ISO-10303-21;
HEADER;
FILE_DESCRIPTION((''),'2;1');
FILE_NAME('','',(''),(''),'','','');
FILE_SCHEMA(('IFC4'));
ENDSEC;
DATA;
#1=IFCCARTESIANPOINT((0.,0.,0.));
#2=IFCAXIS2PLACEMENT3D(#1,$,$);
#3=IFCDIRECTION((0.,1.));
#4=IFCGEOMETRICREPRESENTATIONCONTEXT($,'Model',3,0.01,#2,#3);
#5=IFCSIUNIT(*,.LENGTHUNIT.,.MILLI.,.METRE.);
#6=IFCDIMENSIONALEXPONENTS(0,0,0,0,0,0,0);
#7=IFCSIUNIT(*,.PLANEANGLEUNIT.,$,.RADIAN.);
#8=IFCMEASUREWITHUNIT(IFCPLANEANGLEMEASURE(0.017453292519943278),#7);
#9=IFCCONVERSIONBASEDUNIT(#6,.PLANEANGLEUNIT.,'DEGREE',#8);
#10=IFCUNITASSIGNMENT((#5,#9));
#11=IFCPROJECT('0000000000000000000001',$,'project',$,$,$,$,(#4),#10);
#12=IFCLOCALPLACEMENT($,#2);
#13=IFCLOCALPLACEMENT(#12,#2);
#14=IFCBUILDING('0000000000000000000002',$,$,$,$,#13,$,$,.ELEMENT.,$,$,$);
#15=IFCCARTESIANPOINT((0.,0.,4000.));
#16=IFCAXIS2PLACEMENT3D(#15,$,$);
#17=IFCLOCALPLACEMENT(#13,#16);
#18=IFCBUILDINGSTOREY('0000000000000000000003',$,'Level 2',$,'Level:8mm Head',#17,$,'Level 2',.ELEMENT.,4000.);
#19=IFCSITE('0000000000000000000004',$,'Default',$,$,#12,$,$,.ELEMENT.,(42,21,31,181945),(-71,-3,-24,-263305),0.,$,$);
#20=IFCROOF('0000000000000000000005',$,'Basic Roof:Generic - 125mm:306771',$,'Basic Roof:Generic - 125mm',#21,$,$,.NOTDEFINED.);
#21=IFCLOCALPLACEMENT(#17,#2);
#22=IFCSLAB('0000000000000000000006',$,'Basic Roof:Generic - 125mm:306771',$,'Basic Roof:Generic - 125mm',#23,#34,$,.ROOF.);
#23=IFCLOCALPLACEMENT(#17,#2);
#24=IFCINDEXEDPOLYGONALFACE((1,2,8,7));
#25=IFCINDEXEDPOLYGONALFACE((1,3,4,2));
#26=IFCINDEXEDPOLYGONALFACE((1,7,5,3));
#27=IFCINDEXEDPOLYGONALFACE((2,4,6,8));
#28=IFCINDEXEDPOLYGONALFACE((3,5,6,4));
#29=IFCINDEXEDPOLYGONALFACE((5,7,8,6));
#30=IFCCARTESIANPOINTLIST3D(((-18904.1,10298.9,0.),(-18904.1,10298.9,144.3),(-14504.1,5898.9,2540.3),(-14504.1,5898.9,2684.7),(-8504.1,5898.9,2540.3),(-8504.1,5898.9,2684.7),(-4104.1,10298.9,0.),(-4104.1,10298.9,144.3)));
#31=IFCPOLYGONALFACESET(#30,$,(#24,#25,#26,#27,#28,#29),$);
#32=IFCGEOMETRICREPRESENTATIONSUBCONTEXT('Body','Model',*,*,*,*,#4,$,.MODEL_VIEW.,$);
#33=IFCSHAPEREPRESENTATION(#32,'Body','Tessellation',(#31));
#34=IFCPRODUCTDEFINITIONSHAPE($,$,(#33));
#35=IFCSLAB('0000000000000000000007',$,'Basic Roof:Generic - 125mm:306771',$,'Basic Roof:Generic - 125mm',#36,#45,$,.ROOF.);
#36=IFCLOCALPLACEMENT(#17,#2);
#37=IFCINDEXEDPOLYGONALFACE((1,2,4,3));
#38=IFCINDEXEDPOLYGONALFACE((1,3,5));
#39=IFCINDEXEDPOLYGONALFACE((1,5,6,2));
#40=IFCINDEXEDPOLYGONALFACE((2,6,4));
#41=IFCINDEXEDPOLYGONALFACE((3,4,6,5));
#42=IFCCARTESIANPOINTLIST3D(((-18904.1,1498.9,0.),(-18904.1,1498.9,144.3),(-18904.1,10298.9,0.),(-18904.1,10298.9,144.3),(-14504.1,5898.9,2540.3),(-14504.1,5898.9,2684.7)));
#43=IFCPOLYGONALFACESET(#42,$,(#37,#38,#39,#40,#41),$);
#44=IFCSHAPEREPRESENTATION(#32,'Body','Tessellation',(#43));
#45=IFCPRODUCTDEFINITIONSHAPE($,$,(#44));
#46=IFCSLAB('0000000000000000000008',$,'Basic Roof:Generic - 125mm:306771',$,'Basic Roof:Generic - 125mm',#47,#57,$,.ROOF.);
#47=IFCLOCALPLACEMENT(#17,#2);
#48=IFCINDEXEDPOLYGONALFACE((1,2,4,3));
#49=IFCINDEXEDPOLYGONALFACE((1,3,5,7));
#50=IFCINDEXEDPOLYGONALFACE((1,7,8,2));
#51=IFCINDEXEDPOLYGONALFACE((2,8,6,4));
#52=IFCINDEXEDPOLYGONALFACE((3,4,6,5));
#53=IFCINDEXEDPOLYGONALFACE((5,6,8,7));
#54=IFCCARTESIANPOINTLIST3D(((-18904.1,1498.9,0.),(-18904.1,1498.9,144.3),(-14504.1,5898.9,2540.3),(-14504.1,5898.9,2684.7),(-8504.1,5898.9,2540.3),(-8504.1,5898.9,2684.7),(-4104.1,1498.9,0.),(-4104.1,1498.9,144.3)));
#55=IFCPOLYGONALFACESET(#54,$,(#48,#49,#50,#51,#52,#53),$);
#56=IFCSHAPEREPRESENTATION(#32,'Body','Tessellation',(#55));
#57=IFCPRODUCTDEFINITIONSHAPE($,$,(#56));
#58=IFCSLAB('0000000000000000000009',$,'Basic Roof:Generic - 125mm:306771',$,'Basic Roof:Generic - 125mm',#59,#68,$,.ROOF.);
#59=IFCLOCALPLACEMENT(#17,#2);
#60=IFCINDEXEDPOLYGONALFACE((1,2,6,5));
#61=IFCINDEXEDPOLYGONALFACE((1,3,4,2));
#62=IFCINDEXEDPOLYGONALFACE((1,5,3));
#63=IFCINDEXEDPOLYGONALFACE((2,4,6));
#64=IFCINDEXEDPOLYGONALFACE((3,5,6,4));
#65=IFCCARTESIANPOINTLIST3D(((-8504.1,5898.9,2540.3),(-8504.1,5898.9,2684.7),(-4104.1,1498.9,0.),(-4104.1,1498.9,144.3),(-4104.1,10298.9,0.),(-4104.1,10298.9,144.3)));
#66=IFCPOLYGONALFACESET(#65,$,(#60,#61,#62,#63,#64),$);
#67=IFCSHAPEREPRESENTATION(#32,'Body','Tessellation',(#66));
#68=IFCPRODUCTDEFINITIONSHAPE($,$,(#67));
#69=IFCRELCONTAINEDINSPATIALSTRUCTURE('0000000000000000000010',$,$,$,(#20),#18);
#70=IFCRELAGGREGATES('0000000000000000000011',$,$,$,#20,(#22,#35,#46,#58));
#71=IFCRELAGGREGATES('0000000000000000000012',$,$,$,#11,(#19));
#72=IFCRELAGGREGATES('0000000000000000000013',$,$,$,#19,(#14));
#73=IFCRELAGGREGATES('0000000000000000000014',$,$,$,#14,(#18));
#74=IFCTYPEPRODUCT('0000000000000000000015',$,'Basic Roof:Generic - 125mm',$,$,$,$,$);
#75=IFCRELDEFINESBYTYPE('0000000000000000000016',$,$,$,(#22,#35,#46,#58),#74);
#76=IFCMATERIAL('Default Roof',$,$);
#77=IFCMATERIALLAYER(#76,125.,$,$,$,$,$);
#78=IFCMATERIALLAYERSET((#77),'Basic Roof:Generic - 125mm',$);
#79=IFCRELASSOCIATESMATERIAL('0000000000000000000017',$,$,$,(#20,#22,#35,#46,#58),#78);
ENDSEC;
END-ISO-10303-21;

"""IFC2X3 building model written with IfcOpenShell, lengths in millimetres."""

from ifc_helpers import new_model, entity, si_unit, converted_unit, direction, frame, origin, place, context, subcontext, project, spatial, polyline, outline, extrude, material, layer, layer_set, type_object, element, aggregate, save


model = new_model("IFC2X3")

# Units and contexts
model_context = context("Model", 3, precision=0.01, world=origin(), true_north=direction((0.0, 1.0)))
body_context = subcontext(model_context, "Body", "Model", "MODEL_VIEW")
ifc_project = project(units=[si_unit("LENGTHUNIT", "METRE", prefix="MILLI"), converted_unit("PLANEANGLEUNIT", "DEGREE", entity("IfcPlaneAngleMeasure", 0.017453292519943278), si_unit("PLANEANGLEUNIT", "RADIAN"), dimensions=[0, 0, 0, 0, 0, 0, 0])], contexts=[model_context])

# Site, building, storey
site_placement = place(None, origin())
site = spatial("IfcSite", under=ifc_project, at=site_placement, Name="Default", CompositionType="ELEMENT", RefLatitude=(42, 21, 31, 181945), RefLongitude=(-71, -3, -24, -263305), RefElevation=0.0)
building_placement = place(site_placement, origin())
building = spatial("IfcBuilding", under=site, at=building_placement, CompositionType="ELEMENT")
storey_placement = place(building_placement, frame((0.0, 0.0, 4000.0)))
storey = spatial("IfcBuildingStorey", under=building, at=storey_placement, Name="Level 2", ObjectType="Level:8mm Head", LongName="Level 2", CompositionType="ELEMENT", Elevation=4000.0)

# Roof, slabs
ifc_material = material(Name="Default Roof")
ifc_layer = layer(ifc_material, 125.0)
ifc_layer_set = layer_set([ifc_layer], Name="Basic Roof:Generic - 125mm")
roof_placement = place(storey_placement, frame((-18904.1, 1498.9, 0.0)))
roof = element("IfcRoof", 1, at=roof_placement, inside=storey, material=ifc_layer_set, Name="Basic Roof:Generic - 125mm:306771", ObjectType="Basic Roof:Generic - 125mm", ShapeType="NOTDEFINED")
type_product = type_object("IfcTypeProduct", Name="Basic Roof:Generic - 125mm")
slab_1_placement = place(roof_placement, origin())
slab_1 = element("IfcSlab", 2, at=slab_1_placement, type_object=type_product, material=ifc_layer_set, Name="Basic Roof:Generic - 125mm:306771", ObjectType="Basic Roof:Generic - 125mm", PredefinedType="ROOF", context=body_context, shape_type="SweptSolid", body=[
    extrude(outline(polyline([(7400.0, 2540.3), (-7400.0, 2540.3), (-3000.0, -2540.3), (3000.0, -2540.3), (7400.0, 2540.3)])), frame((7400.0, 6600.0, 1270.2), z_axis=(0.0, 0.5, 0.866025), x_axis=(1.0, 0.0, 0.0)), (0.0, -0.5, 0.866025), 144.3),
])
slab_2_placement = place(roof_placement, origin())
slab_2 = element("IfcSlab", 3, at=slab_2_placement, type_object=type_product, material=ifc_layer_set, Name="Basic Roof:Generic - 125mm:306771", ObjectType="Basic Roof:Generic - 125mm", PredefinedType="ROOF", context=body_context, shape_type="SweptSolid", body=[
    extrude(outline(polyline([(-2540.3, 4400.0), (-2540.3, -4400.0), (2540.3, 0.0), (-2540.3, 4400.0)])), frame((2200.0, 4400.0, 1270.2), z_axis=(-0.5, 0.0, 0.866025), x_axis=(0.866025, 0.0, 0.5)), (0.5, 0.0, 0.866025), 144.3),
])
slab_3_placement = place(roof_placement, origin())
slab_3 = element("IfcSlab", 4, at=slab_3_placement, type_object=type_product, material=ifc_layer_set, Name="Basic Roof:Generic - 125mm:306771", ObjectType="Basic Roof:Generic - 125mm", PredefinedType="ROOF", context=body_context, shape_type="SweptSolid", body=[
    extrude(outline(polyline([(-7400.0, -2540.3), (7400.0, -2540.3), (3000.0, 2540.3), (-3000.0, 2540.3), (-7400.0, -2540.3)])), frame((7400.0, 2200.0, 1270.2), z_axis=(0.0, -0.5, 0.866025), x_axis=(1.0, 0.0, 0.0)), (0.0, 0.5, 0.866025), 144.3),
])
slab_4_placement = place(roof_placement, origin())
slab_4 = element("IfcSlab", 5, at=slab_4_placement, type_object=type_product, material=ifc_layer_set, Name="Basic Roof:Generic - 125mm:306771", ObjectType="Basic Roof:Generic - 125mm", PredefinedType="ROOF", context=body_context, shape_type="SweptSolid", body=[
    extrude(outline(polyline([(-2540.3, 0.0), (2540.3, -4400.0), (2540.3, 4400.0), (-2540.3, 0.0)])), frame((12600.0, 4400.0, 1270.2), z_axis=(0.5, 0.0, 0.866025), x_axis=(0.866025, 0.0, -0.5)), (-0.5, 0.0, 0.866025), 144.3),
])
aggregate(roof, [slab_1, slab_2, slab_3, slab_4])

save(model, "model.ifc")
